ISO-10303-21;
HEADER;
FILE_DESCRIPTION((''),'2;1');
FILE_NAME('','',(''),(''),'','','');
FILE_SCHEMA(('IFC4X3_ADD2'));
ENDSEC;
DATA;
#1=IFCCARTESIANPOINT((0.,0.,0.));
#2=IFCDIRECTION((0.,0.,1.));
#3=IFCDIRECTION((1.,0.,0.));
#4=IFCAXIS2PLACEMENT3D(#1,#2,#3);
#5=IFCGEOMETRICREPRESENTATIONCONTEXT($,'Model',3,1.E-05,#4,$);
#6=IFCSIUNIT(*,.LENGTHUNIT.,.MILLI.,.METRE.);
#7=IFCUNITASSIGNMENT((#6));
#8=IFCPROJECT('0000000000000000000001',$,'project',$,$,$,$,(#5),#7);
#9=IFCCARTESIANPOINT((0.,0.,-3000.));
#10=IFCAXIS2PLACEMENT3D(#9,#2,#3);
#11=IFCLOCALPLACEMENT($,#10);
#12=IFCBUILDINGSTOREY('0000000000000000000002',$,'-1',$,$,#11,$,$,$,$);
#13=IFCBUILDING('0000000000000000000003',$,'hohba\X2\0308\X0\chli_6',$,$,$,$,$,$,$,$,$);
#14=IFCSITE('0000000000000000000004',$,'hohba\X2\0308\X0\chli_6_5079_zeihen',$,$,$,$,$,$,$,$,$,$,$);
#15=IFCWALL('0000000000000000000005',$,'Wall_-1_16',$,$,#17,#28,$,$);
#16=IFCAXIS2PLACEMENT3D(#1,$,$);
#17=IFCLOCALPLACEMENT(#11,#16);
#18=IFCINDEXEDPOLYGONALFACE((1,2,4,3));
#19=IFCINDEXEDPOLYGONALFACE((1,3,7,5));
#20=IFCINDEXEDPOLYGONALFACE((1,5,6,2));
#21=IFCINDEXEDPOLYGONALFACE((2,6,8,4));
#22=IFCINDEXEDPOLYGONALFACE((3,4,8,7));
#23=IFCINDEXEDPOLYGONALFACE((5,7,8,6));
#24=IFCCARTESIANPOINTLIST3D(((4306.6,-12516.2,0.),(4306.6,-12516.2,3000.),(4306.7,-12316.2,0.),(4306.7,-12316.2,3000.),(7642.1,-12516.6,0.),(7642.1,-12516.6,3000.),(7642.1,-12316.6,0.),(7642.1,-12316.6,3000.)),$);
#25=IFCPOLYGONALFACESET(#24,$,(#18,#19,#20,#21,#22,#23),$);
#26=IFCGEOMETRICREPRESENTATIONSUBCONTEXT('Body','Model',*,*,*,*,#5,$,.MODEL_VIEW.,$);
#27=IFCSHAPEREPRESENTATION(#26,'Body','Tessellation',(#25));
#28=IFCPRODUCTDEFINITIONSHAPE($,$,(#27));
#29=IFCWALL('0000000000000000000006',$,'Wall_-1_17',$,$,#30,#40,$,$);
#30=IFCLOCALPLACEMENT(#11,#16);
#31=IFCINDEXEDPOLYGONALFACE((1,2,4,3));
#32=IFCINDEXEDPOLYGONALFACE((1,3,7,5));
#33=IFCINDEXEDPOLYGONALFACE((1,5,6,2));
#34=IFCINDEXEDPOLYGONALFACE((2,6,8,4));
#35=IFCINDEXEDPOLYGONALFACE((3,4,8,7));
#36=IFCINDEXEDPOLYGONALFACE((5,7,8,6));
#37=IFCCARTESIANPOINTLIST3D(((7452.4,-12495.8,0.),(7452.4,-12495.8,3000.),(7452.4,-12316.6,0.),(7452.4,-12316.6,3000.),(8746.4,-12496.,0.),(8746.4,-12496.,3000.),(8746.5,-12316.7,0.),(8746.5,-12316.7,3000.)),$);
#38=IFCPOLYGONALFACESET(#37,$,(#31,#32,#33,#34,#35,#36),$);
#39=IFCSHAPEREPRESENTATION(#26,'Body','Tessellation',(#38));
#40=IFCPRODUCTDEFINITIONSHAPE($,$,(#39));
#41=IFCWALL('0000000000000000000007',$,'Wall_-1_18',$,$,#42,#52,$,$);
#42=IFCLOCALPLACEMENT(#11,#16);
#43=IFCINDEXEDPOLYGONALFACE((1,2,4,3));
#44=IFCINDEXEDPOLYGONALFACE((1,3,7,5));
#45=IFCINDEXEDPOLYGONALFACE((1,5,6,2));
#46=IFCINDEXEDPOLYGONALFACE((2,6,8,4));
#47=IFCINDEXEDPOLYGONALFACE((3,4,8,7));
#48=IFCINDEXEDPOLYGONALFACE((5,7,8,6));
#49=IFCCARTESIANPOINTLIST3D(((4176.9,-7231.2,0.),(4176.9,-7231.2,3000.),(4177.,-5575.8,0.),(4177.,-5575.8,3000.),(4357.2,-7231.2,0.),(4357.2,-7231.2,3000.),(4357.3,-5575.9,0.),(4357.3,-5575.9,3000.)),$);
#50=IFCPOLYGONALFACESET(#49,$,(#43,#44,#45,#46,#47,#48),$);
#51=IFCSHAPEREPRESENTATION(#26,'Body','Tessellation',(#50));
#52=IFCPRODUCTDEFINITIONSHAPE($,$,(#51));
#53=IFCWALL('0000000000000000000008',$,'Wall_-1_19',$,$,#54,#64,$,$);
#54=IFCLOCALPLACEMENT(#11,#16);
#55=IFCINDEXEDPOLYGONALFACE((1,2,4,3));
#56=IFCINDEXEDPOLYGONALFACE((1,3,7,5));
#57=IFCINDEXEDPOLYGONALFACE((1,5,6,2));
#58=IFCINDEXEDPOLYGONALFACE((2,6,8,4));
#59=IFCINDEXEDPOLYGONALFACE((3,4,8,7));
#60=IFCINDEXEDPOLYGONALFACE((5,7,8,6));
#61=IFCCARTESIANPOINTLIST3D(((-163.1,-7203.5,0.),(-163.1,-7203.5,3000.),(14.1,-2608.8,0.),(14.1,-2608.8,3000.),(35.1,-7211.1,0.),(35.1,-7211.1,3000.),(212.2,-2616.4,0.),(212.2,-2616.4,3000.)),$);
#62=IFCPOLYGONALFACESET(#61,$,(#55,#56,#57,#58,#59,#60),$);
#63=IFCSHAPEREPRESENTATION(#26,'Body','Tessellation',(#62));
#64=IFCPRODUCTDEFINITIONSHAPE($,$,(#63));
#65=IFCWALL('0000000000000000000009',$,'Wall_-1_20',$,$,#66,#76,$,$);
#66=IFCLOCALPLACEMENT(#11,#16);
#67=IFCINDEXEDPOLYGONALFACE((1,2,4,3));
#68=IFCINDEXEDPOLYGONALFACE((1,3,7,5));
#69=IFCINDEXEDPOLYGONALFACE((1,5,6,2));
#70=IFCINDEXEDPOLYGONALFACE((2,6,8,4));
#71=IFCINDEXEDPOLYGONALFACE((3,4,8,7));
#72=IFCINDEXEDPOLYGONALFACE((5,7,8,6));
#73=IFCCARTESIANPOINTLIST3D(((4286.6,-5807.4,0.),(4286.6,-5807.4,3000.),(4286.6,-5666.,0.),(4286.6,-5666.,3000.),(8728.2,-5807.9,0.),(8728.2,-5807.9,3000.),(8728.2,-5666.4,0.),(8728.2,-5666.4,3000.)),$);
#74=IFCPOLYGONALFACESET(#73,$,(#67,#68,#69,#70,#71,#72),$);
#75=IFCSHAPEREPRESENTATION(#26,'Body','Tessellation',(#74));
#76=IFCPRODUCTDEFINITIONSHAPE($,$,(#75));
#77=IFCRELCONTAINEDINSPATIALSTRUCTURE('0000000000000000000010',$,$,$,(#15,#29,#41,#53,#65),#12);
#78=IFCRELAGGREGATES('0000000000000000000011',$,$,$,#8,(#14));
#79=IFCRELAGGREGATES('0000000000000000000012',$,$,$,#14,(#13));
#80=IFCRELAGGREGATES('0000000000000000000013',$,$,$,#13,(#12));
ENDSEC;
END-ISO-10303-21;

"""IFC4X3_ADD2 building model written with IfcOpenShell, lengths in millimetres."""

from ifc_helpers import new_model, si_unit, frame, origin_with_axes, place, context, subcontext, project, spatial, indexed_curve, outline, extrude, element, save


model = new_model("IFC4X3_ADD2")

# Units and contexts
model_context = context("Model", 3, precision=1e-05, world=origin_with_axes())
body_context = subcontext(model_context, "Body", "Model", "MODEL_VIEW")
ifc_project = project(units=[si_unit("LENGTHUNIT", "METRE", prefix="MILLI")], contexts=[model_context])

# Site, building, storey
site = spatial("IfcSite", under=ifc_project, Name="hohbächli_6_5079_zeihen")
building = spatial("IfcBuilding", under=site, Name="hohbächli_6")
storey_placement = place(None, frame((0.0, 0.0, -3000.0), z_axis=(0.0, 0.0, 1.0), x_axis=(1.0, 0.0, 0.0)))
storey = spatial("IfcBuildingStorey", under=building, at=storey_placement, Name="-1")

# Walls
wall_1_placement = place(storey_placement, frame((7642.1, -12316.6, 0.0), z_axis=(0.0, 0.0, 1.0), x_axis=(-1.0, 0.000098, 0.0)))
element("IfcWall", 1, at=wall_1_placement, inside=storey, Name="Wall_-1_16", context=body_context, shape_type="SweptSolid", body=[
    extrude(outline(indexed_curve([(0.0, 0.0), (0.0, 200.0), (3335.4, 200.0), (3335.4, 0.0), (0.0, 0.0)], self_intersect=False)), origin_with_axes(), (0.0, 0.0, 1.0), 3000.0),
])
wall_2_placement = place(storey_placement, frame((8746.5, -12316.7, 0.0), z_axis=(0.0, 0.0, 1.0), x_axis=(-1.0, 0.000098, 0.0)))
element("IfcWall", 2, at=wall_2_placement, inside=storey, Name="Wall_-1_17", context=body_context, shape_type="SweptSolid", body=[
    extrude(outline(indexed_curve([(0.0, 0.0), (0.0, 179.3), (1294.0, 179.3), (1294.0, 0.0), (0.0, 0.0)], self_intersect=False)), origin_with_axes(), (0.0, 0.0, 1.0), 3000.0),
])
wall_3_placement = place(storey_placement, frame((4357.2, -7231.2, 0.0), z_axis=(0.0, 0.0, 1.0), x_axis=(0.000098, 1.0, 0.0)))
element("IfcWall", 3, at=wall_3_placement, inside=storey, Name="Wall_-1_18", context=body_context, shape_type="SweptSolid", body=[
    extrude(outline(indexed_curve([(0.0, 0.0), (0.0, 180.3), (1655.3, 180.3), (1655.3, 0.0), (0.0, 0.0)], self_intersect=False)), origin_with_axes(), (0.0, 0.0, 1.0), 3000.0),
])
wall_4_placement = place(storey_placement, frame((35.1, -7211.1, 0.0), z_axis=(0.0, 0.0, 1.0), x_axis=(0.038531, 0.999257, 0.0)))
element("IfcWall", 4, at=wall_4_placement, inside=storey, Name="Wall_-1_19", context=body_context, shape_type="SweptSolid", body=[
    extrude(outline(indexed_curve([(0.0, 0.0), (0.0, 198.3), (4598.1, 198.3), (4598.1, 0.0), (0.0, 0.0)], self_intersect=False)), origin_with_axes(), (0.0, 0.0, 1.0), 3000.0),
])
wall_5_placement = place(storey_placement, frame((8728.2, -5666.4, 0.0), z_axis=(0.0, 0.0, 1.0), x_axis=(-1.0, 0.000098, 0.0)))
element("IfcWall", 5, at=wall_5_placement, inside=storey, Name="Wall_-1_20", context=body_context, shape_type="SweptSolid", body=[
    extrude(outline(indexed_curve([(0.0, 0.0), (0.0, 141.4), (4441.6, 141.4), (4441.6, 0.0), (0.0, 0.0)], self_intersect=False)), origin_with_axes(), (0.0, 0.0, 1.0), 3000.0),
])

save(model, "model.ifc")
